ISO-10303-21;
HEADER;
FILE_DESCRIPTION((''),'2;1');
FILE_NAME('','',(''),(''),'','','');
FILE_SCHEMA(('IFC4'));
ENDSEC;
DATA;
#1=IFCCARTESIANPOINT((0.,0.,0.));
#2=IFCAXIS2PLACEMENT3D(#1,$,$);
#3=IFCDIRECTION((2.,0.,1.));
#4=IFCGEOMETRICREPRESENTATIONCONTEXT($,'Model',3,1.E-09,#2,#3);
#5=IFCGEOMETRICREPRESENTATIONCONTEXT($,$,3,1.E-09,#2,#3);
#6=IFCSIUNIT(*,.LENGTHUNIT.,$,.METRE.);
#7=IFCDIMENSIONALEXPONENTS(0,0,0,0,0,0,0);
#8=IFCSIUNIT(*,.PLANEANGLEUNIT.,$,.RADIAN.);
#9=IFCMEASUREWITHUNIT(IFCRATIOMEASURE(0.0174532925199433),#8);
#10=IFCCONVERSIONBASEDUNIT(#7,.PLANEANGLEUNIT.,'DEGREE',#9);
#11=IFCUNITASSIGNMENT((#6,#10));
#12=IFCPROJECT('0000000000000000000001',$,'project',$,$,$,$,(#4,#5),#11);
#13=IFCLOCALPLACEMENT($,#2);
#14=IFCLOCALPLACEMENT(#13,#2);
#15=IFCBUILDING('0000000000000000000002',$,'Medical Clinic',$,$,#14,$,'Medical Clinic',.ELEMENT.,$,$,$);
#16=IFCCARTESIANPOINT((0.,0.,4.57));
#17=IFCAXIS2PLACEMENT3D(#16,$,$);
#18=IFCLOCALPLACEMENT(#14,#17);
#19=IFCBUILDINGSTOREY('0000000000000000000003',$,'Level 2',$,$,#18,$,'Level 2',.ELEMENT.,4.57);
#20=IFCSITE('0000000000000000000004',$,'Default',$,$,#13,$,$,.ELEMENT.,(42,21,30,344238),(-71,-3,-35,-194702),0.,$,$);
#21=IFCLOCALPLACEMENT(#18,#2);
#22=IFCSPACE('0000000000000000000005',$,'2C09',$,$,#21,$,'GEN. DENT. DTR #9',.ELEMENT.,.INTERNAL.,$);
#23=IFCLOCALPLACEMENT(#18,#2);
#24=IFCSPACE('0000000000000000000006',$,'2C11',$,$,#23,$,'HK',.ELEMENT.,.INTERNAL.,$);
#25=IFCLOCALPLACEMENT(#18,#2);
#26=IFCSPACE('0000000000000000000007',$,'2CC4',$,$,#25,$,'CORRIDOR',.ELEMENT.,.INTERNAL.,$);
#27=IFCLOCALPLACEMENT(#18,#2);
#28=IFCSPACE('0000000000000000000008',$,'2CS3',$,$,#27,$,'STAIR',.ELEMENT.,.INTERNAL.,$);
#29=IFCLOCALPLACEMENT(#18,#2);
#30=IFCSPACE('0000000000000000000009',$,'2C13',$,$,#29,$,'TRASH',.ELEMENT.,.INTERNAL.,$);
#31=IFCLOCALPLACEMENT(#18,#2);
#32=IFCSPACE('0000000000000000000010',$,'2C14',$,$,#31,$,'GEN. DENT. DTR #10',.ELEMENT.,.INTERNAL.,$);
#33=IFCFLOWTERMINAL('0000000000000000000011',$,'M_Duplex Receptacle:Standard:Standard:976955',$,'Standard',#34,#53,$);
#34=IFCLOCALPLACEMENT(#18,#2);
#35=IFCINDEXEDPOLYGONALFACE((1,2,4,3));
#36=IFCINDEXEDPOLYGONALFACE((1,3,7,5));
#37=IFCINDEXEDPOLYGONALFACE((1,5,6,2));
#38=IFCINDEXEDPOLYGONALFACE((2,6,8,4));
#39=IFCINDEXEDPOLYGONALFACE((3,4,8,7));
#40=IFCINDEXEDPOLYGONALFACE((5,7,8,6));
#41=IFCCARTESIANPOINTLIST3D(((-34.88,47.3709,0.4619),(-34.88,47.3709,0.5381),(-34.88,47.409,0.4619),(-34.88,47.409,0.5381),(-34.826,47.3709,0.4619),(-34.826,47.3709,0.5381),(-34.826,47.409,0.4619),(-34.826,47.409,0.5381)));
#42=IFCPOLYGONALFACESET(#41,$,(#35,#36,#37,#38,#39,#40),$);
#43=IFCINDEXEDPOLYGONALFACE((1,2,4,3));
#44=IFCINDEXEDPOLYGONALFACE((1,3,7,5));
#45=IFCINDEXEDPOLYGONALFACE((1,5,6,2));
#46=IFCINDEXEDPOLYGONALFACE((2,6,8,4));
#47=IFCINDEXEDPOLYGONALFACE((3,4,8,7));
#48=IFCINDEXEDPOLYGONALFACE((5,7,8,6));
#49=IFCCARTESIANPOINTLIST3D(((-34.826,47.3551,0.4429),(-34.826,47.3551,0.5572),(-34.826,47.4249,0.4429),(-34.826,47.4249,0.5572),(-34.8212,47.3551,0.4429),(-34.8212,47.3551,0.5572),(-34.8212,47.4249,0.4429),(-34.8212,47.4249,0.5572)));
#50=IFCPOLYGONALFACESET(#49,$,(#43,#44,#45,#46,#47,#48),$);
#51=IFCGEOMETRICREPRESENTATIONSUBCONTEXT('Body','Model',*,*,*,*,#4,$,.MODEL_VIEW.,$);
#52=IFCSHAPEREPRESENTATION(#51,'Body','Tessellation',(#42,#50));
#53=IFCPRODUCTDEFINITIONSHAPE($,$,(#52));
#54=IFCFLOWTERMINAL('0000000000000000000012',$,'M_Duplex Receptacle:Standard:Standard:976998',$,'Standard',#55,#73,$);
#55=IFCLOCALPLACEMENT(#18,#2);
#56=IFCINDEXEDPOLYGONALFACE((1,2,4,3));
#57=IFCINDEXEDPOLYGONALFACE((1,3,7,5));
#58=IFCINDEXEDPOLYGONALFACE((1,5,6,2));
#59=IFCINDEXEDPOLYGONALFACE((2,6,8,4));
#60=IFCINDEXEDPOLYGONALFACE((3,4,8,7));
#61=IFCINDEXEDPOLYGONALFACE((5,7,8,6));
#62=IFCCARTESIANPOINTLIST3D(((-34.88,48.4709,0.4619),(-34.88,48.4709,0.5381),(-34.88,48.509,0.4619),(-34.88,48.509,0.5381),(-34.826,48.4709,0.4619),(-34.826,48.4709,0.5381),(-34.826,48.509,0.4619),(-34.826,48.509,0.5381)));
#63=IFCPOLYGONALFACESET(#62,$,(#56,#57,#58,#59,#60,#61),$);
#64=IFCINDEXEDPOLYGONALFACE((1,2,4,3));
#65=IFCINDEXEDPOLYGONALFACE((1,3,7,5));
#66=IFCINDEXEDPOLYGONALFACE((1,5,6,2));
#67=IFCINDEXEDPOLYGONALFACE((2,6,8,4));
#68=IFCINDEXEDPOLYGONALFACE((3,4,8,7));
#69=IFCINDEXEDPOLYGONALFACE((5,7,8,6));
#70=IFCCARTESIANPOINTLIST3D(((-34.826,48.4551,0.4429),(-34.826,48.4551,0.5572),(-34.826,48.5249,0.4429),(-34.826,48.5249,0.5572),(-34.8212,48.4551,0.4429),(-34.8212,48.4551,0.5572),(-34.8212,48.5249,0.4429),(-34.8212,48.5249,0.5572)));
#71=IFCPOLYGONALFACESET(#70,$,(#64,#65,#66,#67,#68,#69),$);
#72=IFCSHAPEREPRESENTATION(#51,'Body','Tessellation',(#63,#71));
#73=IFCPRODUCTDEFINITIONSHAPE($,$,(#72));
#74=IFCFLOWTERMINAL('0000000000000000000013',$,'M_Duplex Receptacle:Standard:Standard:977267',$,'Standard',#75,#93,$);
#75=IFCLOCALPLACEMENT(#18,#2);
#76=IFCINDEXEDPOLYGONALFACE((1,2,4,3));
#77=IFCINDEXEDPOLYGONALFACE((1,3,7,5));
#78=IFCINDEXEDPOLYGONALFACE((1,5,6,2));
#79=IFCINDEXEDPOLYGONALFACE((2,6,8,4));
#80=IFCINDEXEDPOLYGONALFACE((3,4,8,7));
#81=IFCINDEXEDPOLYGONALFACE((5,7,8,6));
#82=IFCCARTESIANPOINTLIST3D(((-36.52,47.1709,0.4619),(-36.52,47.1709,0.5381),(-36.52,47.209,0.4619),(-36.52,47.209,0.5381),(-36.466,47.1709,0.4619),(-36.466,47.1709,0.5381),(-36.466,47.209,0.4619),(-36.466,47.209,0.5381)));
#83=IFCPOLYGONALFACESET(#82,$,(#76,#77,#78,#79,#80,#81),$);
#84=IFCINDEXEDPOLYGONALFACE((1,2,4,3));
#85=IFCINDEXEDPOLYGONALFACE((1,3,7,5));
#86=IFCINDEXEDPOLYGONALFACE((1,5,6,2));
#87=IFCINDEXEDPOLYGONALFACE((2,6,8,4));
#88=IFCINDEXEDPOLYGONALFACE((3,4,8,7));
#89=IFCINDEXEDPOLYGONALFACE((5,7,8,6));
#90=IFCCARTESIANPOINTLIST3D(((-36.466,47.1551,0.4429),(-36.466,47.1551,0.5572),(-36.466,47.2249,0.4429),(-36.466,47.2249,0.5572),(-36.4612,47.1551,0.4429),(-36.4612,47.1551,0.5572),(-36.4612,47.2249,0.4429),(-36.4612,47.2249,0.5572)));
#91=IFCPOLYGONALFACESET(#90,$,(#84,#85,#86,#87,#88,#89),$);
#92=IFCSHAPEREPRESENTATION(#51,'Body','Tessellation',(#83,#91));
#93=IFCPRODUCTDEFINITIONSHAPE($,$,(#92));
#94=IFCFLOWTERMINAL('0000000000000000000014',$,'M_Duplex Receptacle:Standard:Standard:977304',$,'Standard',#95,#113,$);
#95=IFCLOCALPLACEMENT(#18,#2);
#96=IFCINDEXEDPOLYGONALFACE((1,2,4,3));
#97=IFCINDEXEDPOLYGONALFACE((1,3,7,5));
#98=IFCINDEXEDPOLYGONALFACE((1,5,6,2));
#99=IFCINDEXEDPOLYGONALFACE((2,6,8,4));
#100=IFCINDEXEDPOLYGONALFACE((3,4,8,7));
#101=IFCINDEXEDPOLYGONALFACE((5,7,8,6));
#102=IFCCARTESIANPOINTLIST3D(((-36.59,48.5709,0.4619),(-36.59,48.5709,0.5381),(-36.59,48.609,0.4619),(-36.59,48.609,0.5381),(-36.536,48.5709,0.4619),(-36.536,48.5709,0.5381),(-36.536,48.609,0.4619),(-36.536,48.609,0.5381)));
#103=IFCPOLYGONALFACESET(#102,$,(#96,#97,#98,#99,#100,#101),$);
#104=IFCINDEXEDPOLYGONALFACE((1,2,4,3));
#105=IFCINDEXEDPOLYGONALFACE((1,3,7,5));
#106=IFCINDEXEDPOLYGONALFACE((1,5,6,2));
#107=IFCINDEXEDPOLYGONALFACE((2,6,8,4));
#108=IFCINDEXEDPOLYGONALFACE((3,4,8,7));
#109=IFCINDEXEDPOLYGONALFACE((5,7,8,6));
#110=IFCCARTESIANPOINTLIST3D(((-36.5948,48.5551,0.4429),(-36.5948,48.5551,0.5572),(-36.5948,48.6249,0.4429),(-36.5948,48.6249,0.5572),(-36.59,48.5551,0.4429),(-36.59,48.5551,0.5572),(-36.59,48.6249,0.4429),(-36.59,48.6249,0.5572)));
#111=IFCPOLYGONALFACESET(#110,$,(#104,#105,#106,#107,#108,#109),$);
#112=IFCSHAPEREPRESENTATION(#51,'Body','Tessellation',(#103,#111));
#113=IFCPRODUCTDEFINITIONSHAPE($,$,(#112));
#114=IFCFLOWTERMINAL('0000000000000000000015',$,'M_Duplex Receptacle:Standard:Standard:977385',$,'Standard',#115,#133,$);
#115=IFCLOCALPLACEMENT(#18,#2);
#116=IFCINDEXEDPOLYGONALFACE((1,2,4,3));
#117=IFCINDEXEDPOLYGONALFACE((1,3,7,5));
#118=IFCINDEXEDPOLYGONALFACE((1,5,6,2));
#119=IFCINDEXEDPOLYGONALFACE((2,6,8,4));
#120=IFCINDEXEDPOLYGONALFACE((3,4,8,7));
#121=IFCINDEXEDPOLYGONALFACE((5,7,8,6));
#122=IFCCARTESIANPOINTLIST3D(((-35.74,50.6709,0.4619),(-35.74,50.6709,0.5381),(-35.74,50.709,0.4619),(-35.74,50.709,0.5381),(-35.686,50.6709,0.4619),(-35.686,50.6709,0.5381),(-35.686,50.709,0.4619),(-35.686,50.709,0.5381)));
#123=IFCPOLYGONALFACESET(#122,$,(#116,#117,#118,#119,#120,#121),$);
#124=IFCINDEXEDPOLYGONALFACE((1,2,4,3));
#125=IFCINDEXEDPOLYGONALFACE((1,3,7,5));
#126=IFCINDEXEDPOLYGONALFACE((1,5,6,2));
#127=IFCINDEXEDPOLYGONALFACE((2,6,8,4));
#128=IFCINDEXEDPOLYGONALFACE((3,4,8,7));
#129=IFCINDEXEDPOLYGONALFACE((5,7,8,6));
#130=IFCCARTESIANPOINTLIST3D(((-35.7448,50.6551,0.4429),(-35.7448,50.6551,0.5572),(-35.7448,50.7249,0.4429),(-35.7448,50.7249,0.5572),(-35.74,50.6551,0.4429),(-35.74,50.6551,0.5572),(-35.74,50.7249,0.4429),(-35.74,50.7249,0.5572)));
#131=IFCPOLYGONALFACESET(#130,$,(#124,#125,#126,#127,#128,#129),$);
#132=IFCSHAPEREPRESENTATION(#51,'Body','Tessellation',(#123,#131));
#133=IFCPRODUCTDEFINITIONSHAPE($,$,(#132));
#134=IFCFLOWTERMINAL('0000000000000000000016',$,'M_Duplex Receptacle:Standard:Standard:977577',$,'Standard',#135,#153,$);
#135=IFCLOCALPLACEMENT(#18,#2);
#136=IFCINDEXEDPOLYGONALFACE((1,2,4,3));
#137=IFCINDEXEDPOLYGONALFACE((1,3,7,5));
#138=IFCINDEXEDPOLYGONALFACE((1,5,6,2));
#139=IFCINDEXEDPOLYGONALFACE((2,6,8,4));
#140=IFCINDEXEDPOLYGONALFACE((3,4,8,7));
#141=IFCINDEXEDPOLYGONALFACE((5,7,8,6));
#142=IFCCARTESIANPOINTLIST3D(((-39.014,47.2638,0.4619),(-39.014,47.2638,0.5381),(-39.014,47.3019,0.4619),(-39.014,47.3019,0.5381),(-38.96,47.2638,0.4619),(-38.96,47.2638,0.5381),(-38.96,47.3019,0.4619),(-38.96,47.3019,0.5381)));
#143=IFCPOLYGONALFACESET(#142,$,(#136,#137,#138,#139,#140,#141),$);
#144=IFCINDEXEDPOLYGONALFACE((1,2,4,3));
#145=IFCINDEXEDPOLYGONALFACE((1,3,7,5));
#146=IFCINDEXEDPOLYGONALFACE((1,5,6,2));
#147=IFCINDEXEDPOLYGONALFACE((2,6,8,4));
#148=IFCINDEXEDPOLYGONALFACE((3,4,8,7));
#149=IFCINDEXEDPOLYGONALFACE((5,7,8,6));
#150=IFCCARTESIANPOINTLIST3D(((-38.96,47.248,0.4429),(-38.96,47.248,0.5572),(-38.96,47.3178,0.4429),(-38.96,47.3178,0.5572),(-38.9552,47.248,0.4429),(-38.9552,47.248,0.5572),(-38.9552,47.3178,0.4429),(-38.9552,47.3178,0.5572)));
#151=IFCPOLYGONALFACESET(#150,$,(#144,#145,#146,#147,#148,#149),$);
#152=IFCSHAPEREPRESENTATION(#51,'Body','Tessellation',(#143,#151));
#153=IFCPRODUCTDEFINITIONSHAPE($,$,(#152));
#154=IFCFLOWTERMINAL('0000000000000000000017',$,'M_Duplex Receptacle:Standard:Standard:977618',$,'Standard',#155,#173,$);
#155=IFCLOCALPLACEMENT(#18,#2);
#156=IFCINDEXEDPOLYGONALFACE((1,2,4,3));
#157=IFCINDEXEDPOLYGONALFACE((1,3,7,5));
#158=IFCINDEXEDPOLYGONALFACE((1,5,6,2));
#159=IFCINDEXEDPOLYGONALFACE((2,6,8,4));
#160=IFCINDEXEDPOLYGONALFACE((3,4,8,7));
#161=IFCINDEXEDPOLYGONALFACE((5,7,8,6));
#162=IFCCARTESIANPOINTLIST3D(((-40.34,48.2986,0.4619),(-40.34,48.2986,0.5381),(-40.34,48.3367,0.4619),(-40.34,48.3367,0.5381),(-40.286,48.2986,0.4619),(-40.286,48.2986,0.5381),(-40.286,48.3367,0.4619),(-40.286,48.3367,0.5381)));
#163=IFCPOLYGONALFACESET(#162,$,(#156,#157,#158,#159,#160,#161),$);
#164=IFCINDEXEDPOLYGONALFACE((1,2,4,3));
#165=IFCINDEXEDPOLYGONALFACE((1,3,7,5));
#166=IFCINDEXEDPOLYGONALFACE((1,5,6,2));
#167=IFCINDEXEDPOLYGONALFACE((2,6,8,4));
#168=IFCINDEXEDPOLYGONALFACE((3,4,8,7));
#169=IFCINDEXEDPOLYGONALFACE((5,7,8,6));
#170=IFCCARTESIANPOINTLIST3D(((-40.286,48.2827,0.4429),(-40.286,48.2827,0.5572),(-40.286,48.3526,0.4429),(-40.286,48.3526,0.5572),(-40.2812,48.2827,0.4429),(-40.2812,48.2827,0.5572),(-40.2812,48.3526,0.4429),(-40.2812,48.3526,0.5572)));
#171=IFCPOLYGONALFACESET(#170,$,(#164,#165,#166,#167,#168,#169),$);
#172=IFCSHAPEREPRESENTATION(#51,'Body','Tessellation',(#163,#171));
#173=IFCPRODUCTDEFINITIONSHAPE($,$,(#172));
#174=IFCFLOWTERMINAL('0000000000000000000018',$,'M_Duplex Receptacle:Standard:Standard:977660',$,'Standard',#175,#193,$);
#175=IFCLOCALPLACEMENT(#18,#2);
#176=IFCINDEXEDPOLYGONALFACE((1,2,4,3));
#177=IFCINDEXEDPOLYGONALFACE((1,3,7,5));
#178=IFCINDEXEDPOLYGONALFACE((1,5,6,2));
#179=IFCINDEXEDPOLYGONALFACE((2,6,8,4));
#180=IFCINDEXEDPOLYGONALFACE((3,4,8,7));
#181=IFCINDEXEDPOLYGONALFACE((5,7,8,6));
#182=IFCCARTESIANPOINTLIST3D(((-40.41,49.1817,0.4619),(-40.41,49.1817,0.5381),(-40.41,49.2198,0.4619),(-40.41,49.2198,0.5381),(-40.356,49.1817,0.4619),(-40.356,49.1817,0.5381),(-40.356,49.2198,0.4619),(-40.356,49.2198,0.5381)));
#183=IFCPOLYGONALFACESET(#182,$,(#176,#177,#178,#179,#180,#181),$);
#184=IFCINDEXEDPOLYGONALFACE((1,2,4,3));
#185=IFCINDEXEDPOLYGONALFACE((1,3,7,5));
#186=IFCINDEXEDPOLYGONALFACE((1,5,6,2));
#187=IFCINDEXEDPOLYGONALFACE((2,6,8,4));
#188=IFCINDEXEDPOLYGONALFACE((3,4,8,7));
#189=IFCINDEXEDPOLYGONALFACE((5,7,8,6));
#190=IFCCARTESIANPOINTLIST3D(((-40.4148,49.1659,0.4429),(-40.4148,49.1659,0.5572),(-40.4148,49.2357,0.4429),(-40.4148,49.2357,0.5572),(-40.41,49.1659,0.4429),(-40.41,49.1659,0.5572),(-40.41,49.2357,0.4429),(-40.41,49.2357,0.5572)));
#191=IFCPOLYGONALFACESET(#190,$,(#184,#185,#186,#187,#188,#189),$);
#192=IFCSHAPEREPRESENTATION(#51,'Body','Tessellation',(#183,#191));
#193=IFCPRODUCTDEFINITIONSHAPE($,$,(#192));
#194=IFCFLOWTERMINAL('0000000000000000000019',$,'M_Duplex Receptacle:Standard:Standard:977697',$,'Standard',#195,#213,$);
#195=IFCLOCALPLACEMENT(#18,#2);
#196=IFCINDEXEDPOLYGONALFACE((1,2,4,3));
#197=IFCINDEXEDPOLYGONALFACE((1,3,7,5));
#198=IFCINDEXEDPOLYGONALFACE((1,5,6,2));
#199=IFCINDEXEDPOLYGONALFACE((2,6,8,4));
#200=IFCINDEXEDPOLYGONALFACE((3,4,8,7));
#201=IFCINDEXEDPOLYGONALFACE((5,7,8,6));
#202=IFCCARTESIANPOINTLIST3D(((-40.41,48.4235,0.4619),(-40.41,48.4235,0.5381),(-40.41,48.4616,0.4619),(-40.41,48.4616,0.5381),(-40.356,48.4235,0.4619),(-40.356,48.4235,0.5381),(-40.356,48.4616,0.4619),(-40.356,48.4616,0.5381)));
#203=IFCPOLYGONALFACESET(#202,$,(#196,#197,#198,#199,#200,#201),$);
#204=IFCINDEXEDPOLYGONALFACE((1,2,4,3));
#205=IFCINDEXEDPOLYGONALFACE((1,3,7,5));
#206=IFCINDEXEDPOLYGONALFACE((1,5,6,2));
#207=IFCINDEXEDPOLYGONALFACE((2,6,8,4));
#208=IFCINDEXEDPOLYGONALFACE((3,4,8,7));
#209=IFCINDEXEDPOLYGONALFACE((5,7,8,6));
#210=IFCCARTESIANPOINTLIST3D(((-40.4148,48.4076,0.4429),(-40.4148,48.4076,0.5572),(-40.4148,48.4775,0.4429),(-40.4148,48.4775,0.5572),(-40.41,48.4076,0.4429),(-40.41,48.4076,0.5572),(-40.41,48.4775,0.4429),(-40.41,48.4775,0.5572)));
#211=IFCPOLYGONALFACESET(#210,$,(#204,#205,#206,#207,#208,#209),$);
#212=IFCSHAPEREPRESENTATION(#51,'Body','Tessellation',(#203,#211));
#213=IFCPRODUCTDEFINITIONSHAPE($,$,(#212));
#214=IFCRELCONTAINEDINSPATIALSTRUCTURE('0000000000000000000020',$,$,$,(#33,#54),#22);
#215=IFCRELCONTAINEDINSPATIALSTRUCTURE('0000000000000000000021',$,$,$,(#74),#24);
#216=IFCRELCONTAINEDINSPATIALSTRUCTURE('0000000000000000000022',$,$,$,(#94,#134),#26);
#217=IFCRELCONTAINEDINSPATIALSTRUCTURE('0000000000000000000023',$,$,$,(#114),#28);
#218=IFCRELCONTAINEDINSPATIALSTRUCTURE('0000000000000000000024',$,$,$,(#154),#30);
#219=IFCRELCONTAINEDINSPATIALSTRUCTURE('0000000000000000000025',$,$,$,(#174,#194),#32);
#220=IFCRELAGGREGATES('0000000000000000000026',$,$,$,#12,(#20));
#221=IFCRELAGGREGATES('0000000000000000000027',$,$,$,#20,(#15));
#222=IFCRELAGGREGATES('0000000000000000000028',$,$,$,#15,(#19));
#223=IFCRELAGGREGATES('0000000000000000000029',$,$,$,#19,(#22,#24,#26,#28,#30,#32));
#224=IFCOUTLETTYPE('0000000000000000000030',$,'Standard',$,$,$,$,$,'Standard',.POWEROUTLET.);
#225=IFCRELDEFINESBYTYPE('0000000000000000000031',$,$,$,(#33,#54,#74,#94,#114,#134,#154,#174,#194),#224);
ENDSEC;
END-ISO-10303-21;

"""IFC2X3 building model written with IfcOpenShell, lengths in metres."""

from ifc_helpers import new_model, entity, si_unit, converted_unit, direction, frame, frame_2d, origin, origin_2d_with_axis, place, context, subcontext, project, spatial, rectangle, extrude, source, transform, mapped, type_object, type_shapes, element, save


model = new_model("IFC2X3")

# Units and contexts
model_context = context("Model", 3, precision=1e-09, world=origin(), true_north=direction((2.0, 0.0, 1.0)))
context_of_model = context(None, 3, precision=1e-09, world=origin(), true_north=direction((2.0, 0.0, 1.0)))
body_context = subcontext(model_context, "Body", "Model", "MODEL_VIEW")
ifc_project = project(units=[si_unit("LENGTHUNIT", "METRE"), converted_unit("PLANEANGLEUNIT", "DEGREE", entity("IfcRatioMeasure", 0.0174532925199433), si_unit("PLANEANGLEUNIT", "RADIAN"), dimensions=[0, 0, 0, 0, 0, 0, 0])], contexts=[model_context, context_of_model])

# Site, building, storey, space
site_placement = place(None, origin())
site = spatial("IfcSite", under=ifc_project, at=site_placement, Name="Default", CompositionType="ELEMENT", RefLatitude=(42, 21, 30, 344238), RefLongitude=(-71, -3, -35, -194702), RefElevation=0.0)
building_placement = place(site_placement, origin())
building = spatial("IfcBuilding", under=site, at=building_placement, Name="Medical Clinic", LongName="Medical Clinic", CompositionType="ELEMENT")
storey_placement = place(building_placement, frame((0.0, 0.0, 4.57)))
storey = spatial("IfcBuildingStorey", under=building, at=storey_placement, Name="Level 2", LongName="Level 2", CompositionType="ELEMENT", Elevation=4.57)
space_1_placement = place(storey_placement, origin())
space_1 = spatial("IfcSpace", under=storey, at=space_1_placement, Name="2C09", LongName="GEN. DENT. DTR #9", CompositionType="ELEMENT", InteriorOrExteriorSpace="INTERNAL")

# Flow terminals
outlet_type = type_object("IfcOutletType", Name="Standard", ElementType="Standard", PredefinedType="POWEROUTLET")
shared_shape_1 = source(origin(), body_context, "Body", "SweptSolid", [
    extrude(rectangle(XDim=0.0381, YDim=0.0762, at=origin_2d_with_axis()), frame((0.0, 0.0, -0.054), z_axis=(0.0, 0.0, 1.0), x_axis=(-1.0, 0.0, 0.0)), (0.0, 0.0, 1.0), 0.054),
    extrude(rectangle(XDim=0.0698, YDim=0.1143, at=frame_2d((0.0, 0.0), x_axis=(1.0, 0.0))), frame((0.0, 0.0, 0.0), z_axis=(0.0, 0.0, 1.0), x_axis=(-1.0, 0.0, 0.0)), (0.0, 0.0, 1.0), 0.0048),
])
type_shapes(outlet_type, [shared_shape_1])
for number, where, z_axis, x_axis, name in (
    (1, (-34.826, 47.39, 0.5), (1.0, 0.0, 0.0), (0.0, 1.0, 0.0), "M_Duplex Receptacle:Standard:Standard:976955"),
    (2, (-34.826, 48.49, 0.5), (1.0, 0.0, 0.0), (0.0, 1.0, 0.0), "M_Duplex Receptacle:Standard:Standard:976998"),
):
    element("IfcFlowTerminal", number, at=place(space_1_placement, frame(where, z_axis=z_axis, x_axis=x_axis)), inside=space_1, type_object=outlet_type, Name=name, ObjectType="Standard", context=body_context, shape_type="MappedRepresentation", body=[
        mapped(shared_shape_1, transform((0.0, 0.0, 0.0), scale=1.0)),
    ])

# Shared definitions
space_2_placement = place(storey_placement, origin())
space_2 = spatial("IfcSpace", under=storey, at=space_2_placement, Name="2C11", LongName="HK", CompositionType="ELEMENT", InteriorOrExteriorSpace="INTERNAL")

# Flow terminal
flow_terminal_1_placement = place(space_2_placement, frame((-36.466, 47.19, 0.5), z_axis=(1.0, 0.0, 0.0), x_axis=(0.0, 1.0, 0.0)))
element("IfcFlowTerminal", 3, at=flow_terminal_1_placement, inside=space_2, type_object=outlet_type, Name="M_Duplex Receptacle:Standard:Standard:977267", ObjectType="Standard", context=body_context, shape_type="MappedRepresentation", body=[
    mapped(shared_shape_1, transform((0.0, 0.0, 0.0), scale=1.0)),
])

# Shared definitions
space_3_placement = place(storey_placement, origin())
space_3 = spatial("IfcSpace", under=storey, at=space_3_placement, Name="2CC4", LongName="CORRIDOR", CompositionType="ELEMENT", InteriorOrExteriorSpace="INTERNAL")

# Flow terminal
flow_terminal_2_placement = place(space_3_placement, frame((-36.59, 48.59, 0.5), z_axis=(-1.0, 0.0, 0.0), x_axis=(0.0, -1.0, 0.0)))
element("IfcFlowTerminal", 4, at=flow_terminal_2_placement, inside=space_3, type_object=outlet_type, Name="M_Duplex Receptacle:Standard:Standard:977304", ObjectType="Standard", context=body_context, shape_type="MappedRepresentation", body=[
    mapped(shared_shape_1, transform((0.0, 0.0, 0.0), scale=1.0)),
])

# Shared definitions
space_4_placement = place(storey_placement, origin())
space_4 = spatial("IfcSpace", under=storey, at=space_4_placement, Name="2CS3", LongName="STAIR", CompositionType="ELEMENT", InteriorOrExteriorSpace="INTERNAL")

# Flow terminals
flow_terminal_3_placement = place(space_4_placement, frame((-35.74, 50.69, 0.5), z_axis=(-1.0, 0.0, 0.0), x_axis=(0.0, -1.0, 0.0)))
element("IfcFlowTerminal", 5, at=flow_terminal_3_placement, inside=space_4, type_object=outlet_type, Name="M_Duplex Receptacle:Standard:Standard:977385", ObjectType="Standard", context=body_context, shape_type="MappedRepresentation", body=[
    mapped(shared_shape_1, transform((0.0, 0.0, 0.0), scale=1.0)),
])
flow_terminal_4_placement = place(space_3_placement, frame((-38.96, 47.2829, 0.5), z_axis=(1.0, 0.0, 0.0), x_axis=(0.0, 1.0, 0.0)))
element("IfcFlowTerminal", 6, at=flow_terminal_4_placement, inside=space_3, type_object=outlet_type, Name="M_Duplex Receptacle:Standard:Standard:977577", ObjectType="Standard", context=body_context, shape_type="MappedRepresentation", body=[
    mapped(shared_shape_1, transform((0.0, 0.0, 0.0), scale=1.0)),
])

# Shared definitions
space_5_placement = place(storey_placement, origin())
space_5 = spatial("IfcSpace", under=storey, at=space_5_placement, Name="2C13", LongName="TRASH", CompositionType="ELEMENT", InteriorOrExteriorSpace="INTERNAL")

# Flow terminal
flow_terminal_5_placement = place(space_5_placement, frame((-40.286, 48.3177, 0.5), z_axis=(1.0, 0.0, 0.0), x_axis=(0.0, 1.0, 0.0)))
element("IfcFlowTerminal", 7, at=flow_terminal_5_placement, inside=space_5, type_object=outlet_type, Name="M_Duplex Receptacle:Standard:Standard:977618", ObjectType="Standard", context=body_context, shape_type="MappedRepresentation", body=[
    mapped(shared_shape_1, transform((0.0, 0.0, 0.0), scale=1.0)),
])

# Shared definitions
space_6_placement = place(storey_placement, origin())
space_6 = spatial("IfcSpace", under=storey, at=space_6_placement, Name="2C14", LongName="GEN. DENT. DTR #10", CompositionType="ELEMENT", InteriorOrExteriorSpace="INTERNAL")

# Flow terminals
for number, where, z_axis, x_axis, name in (
    (8, (-40.41, 49.2008, 0.5), (-1.0, 0.0, 0.0), (0.0, -1.0, 0.0), "M_Duplex Receptacle:Standard:Standard:977660"),
    (9, (-40.41, 48.4425, 0.5), (-1.0, 0.0, 0.0), (0.0, -1.0, 0.0), "M_Duplex Receptacle:Standard:Standard:977697"),
):
    element("IfcFlowTerminal", number, at=place(space_6_placement, frame(where, z_axis=z_axis, x_axis=x_axis)), inside=space_6, type_object=outlet_type, Name=name, ObjectType="Standard", context=body_context, shape_type="MappedRepresentation", body=[
        mapped(shared_shape_1, transform((0.0, 0.0, 0.0), scale=1.0)),
    ])

save(model, "model.ifc")
